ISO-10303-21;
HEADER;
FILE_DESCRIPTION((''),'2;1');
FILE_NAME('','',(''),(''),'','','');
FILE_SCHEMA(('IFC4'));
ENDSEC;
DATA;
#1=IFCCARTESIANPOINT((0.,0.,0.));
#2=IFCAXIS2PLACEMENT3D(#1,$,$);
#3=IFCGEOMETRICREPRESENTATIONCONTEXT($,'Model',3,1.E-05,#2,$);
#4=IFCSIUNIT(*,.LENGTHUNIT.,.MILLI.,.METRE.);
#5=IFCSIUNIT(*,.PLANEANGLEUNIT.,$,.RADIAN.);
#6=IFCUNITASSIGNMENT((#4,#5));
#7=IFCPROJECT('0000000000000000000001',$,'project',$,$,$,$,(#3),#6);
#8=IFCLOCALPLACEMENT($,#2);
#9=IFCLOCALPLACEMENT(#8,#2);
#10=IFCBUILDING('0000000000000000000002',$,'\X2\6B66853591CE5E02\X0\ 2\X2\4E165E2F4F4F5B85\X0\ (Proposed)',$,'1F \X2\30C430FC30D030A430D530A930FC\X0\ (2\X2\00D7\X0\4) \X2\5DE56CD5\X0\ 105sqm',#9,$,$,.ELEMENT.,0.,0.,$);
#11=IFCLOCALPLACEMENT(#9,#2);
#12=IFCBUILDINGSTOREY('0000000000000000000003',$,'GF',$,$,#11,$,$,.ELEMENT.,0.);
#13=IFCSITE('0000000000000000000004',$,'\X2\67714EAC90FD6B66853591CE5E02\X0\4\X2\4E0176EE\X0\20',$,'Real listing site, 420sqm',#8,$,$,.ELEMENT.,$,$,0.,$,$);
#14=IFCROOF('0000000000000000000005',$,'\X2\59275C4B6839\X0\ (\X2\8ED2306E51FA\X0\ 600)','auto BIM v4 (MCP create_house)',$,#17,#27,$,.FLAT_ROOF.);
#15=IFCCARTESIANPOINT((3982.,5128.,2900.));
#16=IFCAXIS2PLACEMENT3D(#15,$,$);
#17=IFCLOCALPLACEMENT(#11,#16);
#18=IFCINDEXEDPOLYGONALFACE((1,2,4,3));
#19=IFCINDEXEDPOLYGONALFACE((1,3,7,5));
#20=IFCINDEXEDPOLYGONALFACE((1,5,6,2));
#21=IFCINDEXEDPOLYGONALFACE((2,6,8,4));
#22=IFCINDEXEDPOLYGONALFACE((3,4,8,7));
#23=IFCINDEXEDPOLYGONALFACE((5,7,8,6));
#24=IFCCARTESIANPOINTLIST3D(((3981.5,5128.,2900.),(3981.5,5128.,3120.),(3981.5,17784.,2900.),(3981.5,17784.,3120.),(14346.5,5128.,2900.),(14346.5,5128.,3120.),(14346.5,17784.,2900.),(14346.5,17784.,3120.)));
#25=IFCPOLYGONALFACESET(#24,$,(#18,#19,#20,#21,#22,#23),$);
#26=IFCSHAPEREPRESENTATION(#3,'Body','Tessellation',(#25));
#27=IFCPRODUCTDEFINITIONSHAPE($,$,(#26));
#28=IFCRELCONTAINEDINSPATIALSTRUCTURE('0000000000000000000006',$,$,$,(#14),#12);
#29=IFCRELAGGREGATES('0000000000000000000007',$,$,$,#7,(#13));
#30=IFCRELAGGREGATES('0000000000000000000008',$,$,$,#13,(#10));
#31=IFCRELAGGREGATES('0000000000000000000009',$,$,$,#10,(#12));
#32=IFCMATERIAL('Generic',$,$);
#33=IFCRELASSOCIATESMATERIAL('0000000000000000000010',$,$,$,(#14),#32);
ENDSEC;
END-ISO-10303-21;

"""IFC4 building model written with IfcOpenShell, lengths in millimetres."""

from ifc_helpers import new_model, si_unit, frame, frame_2d, origin, place, context, project, spatial, rectangle, extrude, material, element, save


model = new_model("IFC4")

# Units and contexts
model_context = context("Model", 3, precision=1e-05, world=origin())
ifc_project = project(units=[si_unit("LENGTHUNIT", "METRE", prefix="MILLI"), si_unit("PLANEANGLEUNIT", "RADIAN")], contexts=[model_context])

# Site, building, storey
site_placement = place(None, origin())
site = spatial("IfcSite", under=ifc_project, at=site_placement, Name="東京都武蔵野市4丁目20", ObjectType="Real listing site, 420sqm", CompositionType="ELEMENT", RefElevation=0.0)
building_placement = place(site_placement, origin())
building = spatial("IfcBuilding", under=site, at=building_placement, Name="武蔵野市 2世帯住宅 (Proposed)", ObjectType="1F ツーバイフォー (2×4) 工法 105sqm", CompositionType="ELEMENT", ElevationOfRefHeight=0.0, ElevationOfTerrain=0.0)
storey_placement = place(building_placement, origin())
storey = spatial("IfcBuildingStorey", under=building, at=storey_placement, Name="GF", CompositionType="ELEMENT", Elevation=0.0)

# Shared definitions
ifc_material = material(Name="Generic")

# Roof
roof_placement = place(storey_placement, frame((3982.0, 5128.0, 2900.0)))
element("IfcRoof", 1, at=roof_placement, inside=storey, material=ifc_material, Name="大屋根 (軒の出 600)", Description="auto BIM v4 (MCP create_house)", PredefinedType="FLAT_ROOF", context=model_context, shape_type="SweptSolid", body=[
    extrude(rectangle(XDim=10365.0, YDim=12656.0, at=frame_2d((5182.0, 6328.0))), frame((3982.0, 5128.0, 2900.0)), (0.0, 0.0, 1.0), 220.0),
])

save(model, "model.ifc")
